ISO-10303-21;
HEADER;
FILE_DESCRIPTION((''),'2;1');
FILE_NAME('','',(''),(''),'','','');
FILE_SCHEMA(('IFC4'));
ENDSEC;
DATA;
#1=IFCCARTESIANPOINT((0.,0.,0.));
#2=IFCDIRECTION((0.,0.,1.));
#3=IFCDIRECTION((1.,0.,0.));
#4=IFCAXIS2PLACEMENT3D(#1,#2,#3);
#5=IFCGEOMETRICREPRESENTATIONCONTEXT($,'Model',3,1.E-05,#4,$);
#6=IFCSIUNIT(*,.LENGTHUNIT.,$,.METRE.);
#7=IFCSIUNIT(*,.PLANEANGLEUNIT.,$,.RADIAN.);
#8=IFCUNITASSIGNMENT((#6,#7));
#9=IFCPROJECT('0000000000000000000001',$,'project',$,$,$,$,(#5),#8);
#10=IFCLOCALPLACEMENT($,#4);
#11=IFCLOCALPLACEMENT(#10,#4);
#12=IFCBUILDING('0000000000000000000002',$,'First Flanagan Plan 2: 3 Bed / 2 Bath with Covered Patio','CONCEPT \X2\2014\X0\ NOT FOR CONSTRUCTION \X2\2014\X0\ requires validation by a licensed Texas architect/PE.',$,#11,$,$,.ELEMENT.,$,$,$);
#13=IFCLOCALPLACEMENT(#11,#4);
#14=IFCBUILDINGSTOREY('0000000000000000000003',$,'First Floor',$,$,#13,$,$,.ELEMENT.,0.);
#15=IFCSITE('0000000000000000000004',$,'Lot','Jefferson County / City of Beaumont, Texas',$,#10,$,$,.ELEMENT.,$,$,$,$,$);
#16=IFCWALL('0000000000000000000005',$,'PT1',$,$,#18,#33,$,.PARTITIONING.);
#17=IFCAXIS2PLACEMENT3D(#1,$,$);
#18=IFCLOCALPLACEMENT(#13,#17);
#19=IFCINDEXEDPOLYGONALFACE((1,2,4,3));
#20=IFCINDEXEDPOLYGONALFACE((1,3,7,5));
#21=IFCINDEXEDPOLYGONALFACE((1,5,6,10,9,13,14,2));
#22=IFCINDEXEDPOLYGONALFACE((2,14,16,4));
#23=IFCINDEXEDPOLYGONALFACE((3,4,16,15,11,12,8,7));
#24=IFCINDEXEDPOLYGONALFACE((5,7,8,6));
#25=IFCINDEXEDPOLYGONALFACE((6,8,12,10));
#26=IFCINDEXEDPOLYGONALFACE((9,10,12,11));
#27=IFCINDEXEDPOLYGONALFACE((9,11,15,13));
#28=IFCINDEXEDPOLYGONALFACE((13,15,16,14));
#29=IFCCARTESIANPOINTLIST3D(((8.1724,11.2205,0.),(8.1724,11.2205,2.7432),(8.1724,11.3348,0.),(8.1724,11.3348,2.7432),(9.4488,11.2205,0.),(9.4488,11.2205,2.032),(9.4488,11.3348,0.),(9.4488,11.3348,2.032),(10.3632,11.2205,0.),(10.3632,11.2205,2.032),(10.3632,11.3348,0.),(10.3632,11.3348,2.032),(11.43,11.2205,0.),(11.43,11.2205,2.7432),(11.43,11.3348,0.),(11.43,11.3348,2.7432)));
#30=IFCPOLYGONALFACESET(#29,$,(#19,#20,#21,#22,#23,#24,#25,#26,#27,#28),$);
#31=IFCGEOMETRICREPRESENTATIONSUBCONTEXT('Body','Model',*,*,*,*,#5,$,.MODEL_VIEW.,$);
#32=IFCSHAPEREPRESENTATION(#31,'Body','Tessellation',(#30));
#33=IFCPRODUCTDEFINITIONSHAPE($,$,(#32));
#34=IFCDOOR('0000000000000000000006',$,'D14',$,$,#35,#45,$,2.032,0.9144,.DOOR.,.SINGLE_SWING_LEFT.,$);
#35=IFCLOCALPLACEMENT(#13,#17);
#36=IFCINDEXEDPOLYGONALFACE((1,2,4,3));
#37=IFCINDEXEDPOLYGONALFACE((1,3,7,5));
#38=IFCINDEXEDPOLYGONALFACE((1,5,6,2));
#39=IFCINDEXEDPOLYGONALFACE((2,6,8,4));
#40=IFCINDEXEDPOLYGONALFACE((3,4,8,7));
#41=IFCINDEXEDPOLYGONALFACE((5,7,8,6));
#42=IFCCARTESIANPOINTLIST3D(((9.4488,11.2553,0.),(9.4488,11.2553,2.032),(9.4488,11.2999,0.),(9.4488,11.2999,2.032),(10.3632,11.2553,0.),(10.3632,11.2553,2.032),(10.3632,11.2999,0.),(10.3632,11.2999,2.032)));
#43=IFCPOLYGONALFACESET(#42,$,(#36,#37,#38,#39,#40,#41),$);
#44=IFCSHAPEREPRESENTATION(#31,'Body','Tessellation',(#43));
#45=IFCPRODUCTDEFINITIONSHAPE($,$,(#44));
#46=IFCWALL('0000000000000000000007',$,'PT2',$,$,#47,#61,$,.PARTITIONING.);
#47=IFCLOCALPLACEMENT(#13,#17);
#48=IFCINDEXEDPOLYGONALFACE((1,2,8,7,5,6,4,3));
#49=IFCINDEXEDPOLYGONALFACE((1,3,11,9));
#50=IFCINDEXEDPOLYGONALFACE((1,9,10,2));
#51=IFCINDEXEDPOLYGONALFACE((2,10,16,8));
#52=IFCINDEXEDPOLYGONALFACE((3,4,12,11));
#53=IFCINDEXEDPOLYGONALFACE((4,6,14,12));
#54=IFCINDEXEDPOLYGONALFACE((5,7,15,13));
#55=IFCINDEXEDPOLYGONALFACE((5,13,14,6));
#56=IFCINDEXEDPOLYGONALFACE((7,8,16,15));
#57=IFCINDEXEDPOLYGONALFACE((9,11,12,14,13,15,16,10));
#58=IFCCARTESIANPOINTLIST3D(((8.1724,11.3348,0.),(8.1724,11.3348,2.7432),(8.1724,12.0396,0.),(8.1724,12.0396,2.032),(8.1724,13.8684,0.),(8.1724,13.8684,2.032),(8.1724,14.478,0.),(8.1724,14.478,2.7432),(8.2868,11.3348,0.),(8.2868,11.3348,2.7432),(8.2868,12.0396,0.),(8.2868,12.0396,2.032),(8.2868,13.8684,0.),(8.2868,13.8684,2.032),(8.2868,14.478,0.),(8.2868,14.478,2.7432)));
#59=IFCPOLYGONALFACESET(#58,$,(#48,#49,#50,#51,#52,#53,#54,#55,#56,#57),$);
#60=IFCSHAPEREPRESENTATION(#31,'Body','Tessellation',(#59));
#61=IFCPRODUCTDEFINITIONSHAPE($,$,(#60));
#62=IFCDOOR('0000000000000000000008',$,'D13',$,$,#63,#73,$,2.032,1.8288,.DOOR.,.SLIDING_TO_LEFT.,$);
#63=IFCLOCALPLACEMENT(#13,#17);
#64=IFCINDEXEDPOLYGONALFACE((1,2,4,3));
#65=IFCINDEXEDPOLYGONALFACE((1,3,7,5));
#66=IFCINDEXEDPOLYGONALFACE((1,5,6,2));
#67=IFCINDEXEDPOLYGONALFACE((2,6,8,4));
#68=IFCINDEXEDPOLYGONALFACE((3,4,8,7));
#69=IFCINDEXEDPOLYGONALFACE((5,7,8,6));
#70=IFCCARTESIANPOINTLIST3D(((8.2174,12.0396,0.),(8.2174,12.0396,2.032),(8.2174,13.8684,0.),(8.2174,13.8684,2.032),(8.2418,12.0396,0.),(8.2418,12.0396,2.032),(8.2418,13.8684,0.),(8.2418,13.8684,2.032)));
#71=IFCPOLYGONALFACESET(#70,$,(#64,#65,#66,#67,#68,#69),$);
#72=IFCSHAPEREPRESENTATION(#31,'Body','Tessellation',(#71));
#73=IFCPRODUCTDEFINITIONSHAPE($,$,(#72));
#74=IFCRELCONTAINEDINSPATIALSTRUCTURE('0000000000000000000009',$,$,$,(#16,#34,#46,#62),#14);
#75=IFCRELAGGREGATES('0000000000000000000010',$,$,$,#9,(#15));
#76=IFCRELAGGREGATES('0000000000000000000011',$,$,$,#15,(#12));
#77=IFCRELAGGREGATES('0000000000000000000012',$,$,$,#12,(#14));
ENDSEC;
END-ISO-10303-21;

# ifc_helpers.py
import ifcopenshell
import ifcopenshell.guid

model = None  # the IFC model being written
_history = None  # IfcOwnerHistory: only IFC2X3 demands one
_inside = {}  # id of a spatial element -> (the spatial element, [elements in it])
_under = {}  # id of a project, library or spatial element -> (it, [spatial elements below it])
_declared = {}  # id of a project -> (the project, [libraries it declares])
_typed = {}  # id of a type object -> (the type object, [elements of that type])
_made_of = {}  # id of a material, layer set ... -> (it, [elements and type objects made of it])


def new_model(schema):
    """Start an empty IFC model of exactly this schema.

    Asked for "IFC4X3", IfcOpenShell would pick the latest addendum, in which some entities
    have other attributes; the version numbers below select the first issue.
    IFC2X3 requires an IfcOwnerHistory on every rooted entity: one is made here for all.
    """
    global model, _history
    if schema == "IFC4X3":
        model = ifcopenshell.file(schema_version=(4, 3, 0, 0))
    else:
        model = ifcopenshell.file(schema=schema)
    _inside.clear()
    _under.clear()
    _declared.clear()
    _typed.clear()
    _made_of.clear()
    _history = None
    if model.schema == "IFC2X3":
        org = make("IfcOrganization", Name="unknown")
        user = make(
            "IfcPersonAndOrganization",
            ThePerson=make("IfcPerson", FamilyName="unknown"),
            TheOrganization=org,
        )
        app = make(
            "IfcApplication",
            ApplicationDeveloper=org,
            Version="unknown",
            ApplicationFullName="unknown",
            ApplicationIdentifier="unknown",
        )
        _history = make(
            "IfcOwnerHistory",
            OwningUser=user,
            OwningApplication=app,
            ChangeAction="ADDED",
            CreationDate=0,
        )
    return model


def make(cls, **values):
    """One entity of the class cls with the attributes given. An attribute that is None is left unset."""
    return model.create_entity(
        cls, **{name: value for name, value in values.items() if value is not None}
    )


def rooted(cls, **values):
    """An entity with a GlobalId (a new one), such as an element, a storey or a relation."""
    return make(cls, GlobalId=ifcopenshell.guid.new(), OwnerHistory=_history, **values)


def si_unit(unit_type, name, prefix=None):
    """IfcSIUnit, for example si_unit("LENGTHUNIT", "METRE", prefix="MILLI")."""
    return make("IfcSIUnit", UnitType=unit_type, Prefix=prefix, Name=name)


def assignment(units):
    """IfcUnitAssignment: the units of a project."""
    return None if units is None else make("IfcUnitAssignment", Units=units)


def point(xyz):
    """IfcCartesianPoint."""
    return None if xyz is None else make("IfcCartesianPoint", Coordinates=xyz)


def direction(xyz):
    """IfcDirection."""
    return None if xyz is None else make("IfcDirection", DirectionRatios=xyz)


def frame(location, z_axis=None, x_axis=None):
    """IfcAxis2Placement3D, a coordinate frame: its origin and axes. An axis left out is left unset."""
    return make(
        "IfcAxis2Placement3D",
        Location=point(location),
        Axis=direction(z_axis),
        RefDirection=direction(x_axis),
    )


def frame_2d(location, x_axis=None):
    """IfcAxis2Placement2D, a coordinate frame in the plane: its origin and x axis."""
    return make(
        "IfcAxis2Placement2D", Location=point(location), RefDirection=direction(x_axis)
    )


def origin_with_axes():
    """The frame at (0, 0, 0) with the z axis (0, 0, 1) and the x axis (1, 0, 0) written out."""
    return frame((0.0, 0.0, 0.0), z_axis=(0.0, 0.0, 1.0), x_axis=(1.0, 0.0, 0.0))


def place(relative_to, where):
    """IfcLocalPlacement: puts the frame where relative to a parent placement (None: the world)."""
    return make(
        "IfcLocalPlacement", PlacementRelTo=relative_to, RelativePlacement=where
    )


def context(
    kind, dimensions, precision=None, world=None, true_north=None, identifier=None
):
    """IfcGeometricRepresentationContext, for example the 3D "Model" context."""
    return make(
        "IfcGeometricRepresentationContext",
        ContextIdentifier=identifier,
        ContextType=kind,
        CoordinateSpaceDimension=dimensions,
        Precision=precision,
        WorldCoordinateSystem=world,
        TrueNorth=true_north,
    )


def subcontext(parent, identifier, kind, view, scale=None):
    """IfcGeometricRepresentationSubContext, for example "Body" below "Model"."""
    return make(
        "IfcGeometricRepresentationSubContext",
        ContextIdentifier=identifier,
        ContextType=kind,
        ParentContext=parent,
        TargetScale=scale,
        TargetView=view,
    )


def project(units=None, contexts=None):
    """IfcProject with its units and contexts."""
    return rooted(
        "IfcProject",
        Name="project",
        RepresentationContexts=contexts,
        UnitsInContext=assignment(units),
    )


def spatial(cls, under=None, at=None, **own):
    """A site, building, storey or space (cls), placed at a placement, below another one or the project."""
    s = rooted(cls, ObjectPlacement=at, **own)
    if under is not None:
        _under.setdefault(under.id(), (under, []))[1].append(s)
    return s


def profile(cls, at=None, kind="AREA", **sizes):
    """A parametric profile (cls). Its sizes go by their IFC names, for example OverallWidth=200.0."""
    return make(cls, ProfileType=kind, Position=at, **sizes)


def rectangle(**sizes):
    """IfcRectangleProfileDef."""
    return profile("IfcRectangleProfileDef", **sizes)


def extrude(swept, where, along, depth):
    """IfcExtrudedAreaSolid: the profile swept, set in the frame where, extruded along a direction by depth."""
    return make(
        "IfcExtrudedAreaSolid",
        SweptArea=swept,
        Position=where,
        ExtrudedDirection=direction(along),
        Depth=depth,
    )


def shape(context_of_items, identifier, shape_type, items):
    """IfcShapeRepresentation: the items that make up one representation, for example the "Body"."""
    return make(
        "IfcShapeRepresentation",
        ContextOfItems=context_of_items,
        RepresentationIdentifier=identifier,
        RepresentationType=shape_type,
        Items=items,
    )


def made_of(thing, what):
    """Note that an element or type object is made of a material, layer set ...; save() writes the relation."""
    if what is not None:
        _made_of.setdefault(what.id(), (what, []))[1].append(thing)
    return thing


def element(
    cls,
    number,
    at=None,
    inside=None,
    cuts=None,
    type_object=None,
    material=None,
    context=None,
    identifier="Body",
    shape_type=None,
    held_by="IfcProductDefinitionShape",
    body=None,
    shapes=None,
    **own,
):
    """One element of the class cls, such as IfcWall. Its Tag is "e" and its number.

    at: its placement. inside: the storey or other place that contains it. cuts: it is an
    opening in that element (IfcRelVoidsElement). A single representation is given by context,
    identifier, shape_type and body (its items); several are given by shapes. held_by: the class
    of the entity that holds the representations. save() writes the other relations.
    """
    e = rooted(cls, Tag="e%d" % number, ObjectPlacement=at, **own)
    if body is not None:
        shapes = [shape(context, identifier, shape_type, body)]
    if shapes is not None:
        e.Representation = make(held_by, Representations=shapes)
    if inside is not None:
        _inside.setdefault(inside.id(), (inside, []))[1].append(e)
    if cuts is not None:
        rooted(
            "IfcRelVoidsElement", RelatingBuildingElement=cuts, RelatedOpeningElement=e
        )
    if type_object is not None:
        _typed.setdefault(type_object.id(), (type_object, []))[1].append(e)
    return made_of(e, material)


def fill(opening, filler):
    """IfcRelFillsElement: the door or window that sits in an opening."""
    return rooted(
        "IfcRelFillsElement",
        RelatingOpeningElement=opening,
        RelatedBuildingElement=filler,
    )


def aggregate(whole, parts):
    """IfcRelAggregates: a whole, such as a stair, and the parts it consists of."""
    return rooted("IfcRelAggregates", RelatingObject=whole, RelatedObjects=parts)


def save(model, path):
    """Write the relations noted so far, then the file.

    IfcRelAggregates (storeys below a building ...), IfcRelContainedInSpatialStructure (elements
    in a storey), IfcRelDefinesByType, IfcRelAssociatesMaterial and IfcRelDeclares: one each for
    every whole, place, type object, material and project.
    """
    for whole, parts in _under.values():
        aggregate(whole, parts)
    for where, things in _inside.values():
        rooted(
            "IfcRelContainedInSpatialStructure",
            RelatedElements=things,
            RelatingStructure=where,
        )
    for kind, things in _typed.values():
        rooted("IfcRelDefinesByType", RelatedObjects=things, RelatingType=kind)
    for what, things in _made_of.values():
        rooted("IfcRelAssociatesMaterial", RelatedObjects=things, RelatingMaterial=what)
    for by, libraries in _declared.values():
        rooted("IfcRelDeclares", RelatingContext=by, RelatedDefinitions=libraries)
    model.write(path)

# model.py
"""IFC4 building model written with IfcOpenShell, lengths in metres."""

from ifc_helpers import new_model, si_unit, frame, frame_2d, origin_with_axes, place, context, subcontext, project, spatial, rectangle, extrude, element, fill, save


model = new_model("IFC4")

# Units and contexts
model_context = context("Model", 3, precision=1e-05, world=origin_with_axes())
body_context = subcontext(model_context, "Body", "Model", "MODEL_VIEW")
ifc_project = project(units=[si_unit("LENGTHUNIT", "METRE"), si_unit("PLANEANGLEUNIT", "RADIAN")], contexts=[model_context])

# Site, building, storey
site_placement = place(None, origin_with_axes())
site = spatial("IfcSite", under=ifc_project, at=site_placement, Name="Lot", Description="Jefferson County / City of Beaumont, Texas", CompositionType="ELEMENT")
building_placement = place(site_placement, origin_with_axes())
building = spatial("IfcBuilding", under=site, at=building_placement, Name="First Flanagan Plan 2: 3 Bed / 2 Bath with Covered Patio", Description="CONCEPT — NOT FOR CONSTRUCTION — requires validation by a licensed Texas architect/PE.", CompositionType="ELEMENT")
storey_placement = place(building_placement, origin_with_axes())
storey = spatial("IfcBuildingStorey", under=building, at=storey_placement, Name="First Floor", CompositionType="ELEMENT", Elevation=0.0)

# Walls, openings, doors
wall_1_placement = place(storey_placement, frame((8.1724, 11.2776, 0.0), z_axis=(0.0, 0.0, 1.0), x_axis=(1.0, 0.0, 0.0)))
wall_1 = element("IfcWall", 1, at=wall_1_placement, inside=storey, Name="PT1", PredefinedType="PARTITIONING", context=body_context, shape_type="SweptSolid", body=[
    extrude(rectangle(XDim=3.2576, YDim=0.1143, at=frame_2d((1.6288, 0.0), x_axis=(1.0, 0.0))), origin_with_axes(), (0.0, 0.0, 1.0), 2.7432),
])
opening_1_placement = place(wall_1_placement, frame((1.2764, 0.0, 0.0), z_axis=(0.0, 0.0, 1.0), x_axis=(1.0, 0.0, 0.0)))
opening_1 = element("IfcOpeningElement", 2, at=opening_1_placement, cuts=wall_1, PredefinedType="OPENING", context=body_context, shape_type="SweptSolid", body=[
    extrude(rectangle(XDim=0.9144, YDim=0.1448, at=frame_2d((0.4572, 0.0), x_axis=(1.0, 0.0))), origin_with_axes(), (0.0, 0.0, 1.0), 2.032),
])
door_1_placement = place(opening_1_placement, origin_with_axes())
door_1 = element("IfcDoor", 3, at=door_1_placement, inside=storey, Name="D14", OperationType="SINGLE_SWING_LEFT", OverallHeight=2.032, OverallWidth=0.9144, PredefinedType="DOOR", context=body_context, shape_type="SweptSolid", body=[
    extrude(rectangle(XDim=0.9144, YDim=0.0445, at=frame_2d((0.4572, 0.0), x_axis=(1.0, 0.0))), origin_with_axes(), (0.0, 0.0, 1.0), 2.032),
])
fill(opening_1, door_1)
wall_2_placement = place(storey_placement, frame((8.2296, 11.3348, 0.0), z_axis=(0.0, 0.0, 1.0), x_axis=(0.0, 1.0, 0.0)))
wall_2 = element("IfcWall", 4, at=wall_2_placement, inside=storey, Name="PT2", PredefinedType="PARTITIONING", context=body_context, shape_type="SweptSolid", body=[
    extrude(rectangle(XDim=3.1433, YDim=0.1143, at=frame_2d((1.5716, 0.0), x_axis=(1.0, 0.0))), origin_with_axes(), (0.0, 0.0, 1.0), 2.7432),
])
opening_2_placement = place(wall_2_placement, frame((0.7049, 0.0, 0.0), z_axis=(0.0, 0.0, 1.0), x_axis=(1.0, 0.0, 0.0)))
opening_2 = element("IfcOpeningElement", 5, at=opening_2_placement, cuts=wall_2, PredefinedType="OPENING", context=body_context, shape_type="SweptSolid", body=[
    extrude(rectangle(XDim=1.8288, YDim=0.1448, at=frame_2d((0.9144, 0.0), x_axis=(1.0, 0.0))), origin_with_axes(), (0.0, 0.0, 1.0), 2.032),
])
door_2_placement = place(opening_2_placement, origin_with_axes())
door_2 = element("IfcDoor", 6, at=door_2_placement, inside=storey, Name="D13", OperationType="SLIDING_TO_LEFT", OverallHeight=2.032, OverallWidth=1.8288, PredefinedType="DOOR", context=body_context, shape_type="SweptSolid", body=[
    extrude(rectangle(XDim=1.8288, YDim=0.0244, at=frame_2d((0.9144, 0.0), x_axis=(1.0, 0.0))), origin_with_axes(), (0.0, 0.0, 1.0), 2.032),
])
fill(opening_2, door_2)

save(model, "model.ifc")
